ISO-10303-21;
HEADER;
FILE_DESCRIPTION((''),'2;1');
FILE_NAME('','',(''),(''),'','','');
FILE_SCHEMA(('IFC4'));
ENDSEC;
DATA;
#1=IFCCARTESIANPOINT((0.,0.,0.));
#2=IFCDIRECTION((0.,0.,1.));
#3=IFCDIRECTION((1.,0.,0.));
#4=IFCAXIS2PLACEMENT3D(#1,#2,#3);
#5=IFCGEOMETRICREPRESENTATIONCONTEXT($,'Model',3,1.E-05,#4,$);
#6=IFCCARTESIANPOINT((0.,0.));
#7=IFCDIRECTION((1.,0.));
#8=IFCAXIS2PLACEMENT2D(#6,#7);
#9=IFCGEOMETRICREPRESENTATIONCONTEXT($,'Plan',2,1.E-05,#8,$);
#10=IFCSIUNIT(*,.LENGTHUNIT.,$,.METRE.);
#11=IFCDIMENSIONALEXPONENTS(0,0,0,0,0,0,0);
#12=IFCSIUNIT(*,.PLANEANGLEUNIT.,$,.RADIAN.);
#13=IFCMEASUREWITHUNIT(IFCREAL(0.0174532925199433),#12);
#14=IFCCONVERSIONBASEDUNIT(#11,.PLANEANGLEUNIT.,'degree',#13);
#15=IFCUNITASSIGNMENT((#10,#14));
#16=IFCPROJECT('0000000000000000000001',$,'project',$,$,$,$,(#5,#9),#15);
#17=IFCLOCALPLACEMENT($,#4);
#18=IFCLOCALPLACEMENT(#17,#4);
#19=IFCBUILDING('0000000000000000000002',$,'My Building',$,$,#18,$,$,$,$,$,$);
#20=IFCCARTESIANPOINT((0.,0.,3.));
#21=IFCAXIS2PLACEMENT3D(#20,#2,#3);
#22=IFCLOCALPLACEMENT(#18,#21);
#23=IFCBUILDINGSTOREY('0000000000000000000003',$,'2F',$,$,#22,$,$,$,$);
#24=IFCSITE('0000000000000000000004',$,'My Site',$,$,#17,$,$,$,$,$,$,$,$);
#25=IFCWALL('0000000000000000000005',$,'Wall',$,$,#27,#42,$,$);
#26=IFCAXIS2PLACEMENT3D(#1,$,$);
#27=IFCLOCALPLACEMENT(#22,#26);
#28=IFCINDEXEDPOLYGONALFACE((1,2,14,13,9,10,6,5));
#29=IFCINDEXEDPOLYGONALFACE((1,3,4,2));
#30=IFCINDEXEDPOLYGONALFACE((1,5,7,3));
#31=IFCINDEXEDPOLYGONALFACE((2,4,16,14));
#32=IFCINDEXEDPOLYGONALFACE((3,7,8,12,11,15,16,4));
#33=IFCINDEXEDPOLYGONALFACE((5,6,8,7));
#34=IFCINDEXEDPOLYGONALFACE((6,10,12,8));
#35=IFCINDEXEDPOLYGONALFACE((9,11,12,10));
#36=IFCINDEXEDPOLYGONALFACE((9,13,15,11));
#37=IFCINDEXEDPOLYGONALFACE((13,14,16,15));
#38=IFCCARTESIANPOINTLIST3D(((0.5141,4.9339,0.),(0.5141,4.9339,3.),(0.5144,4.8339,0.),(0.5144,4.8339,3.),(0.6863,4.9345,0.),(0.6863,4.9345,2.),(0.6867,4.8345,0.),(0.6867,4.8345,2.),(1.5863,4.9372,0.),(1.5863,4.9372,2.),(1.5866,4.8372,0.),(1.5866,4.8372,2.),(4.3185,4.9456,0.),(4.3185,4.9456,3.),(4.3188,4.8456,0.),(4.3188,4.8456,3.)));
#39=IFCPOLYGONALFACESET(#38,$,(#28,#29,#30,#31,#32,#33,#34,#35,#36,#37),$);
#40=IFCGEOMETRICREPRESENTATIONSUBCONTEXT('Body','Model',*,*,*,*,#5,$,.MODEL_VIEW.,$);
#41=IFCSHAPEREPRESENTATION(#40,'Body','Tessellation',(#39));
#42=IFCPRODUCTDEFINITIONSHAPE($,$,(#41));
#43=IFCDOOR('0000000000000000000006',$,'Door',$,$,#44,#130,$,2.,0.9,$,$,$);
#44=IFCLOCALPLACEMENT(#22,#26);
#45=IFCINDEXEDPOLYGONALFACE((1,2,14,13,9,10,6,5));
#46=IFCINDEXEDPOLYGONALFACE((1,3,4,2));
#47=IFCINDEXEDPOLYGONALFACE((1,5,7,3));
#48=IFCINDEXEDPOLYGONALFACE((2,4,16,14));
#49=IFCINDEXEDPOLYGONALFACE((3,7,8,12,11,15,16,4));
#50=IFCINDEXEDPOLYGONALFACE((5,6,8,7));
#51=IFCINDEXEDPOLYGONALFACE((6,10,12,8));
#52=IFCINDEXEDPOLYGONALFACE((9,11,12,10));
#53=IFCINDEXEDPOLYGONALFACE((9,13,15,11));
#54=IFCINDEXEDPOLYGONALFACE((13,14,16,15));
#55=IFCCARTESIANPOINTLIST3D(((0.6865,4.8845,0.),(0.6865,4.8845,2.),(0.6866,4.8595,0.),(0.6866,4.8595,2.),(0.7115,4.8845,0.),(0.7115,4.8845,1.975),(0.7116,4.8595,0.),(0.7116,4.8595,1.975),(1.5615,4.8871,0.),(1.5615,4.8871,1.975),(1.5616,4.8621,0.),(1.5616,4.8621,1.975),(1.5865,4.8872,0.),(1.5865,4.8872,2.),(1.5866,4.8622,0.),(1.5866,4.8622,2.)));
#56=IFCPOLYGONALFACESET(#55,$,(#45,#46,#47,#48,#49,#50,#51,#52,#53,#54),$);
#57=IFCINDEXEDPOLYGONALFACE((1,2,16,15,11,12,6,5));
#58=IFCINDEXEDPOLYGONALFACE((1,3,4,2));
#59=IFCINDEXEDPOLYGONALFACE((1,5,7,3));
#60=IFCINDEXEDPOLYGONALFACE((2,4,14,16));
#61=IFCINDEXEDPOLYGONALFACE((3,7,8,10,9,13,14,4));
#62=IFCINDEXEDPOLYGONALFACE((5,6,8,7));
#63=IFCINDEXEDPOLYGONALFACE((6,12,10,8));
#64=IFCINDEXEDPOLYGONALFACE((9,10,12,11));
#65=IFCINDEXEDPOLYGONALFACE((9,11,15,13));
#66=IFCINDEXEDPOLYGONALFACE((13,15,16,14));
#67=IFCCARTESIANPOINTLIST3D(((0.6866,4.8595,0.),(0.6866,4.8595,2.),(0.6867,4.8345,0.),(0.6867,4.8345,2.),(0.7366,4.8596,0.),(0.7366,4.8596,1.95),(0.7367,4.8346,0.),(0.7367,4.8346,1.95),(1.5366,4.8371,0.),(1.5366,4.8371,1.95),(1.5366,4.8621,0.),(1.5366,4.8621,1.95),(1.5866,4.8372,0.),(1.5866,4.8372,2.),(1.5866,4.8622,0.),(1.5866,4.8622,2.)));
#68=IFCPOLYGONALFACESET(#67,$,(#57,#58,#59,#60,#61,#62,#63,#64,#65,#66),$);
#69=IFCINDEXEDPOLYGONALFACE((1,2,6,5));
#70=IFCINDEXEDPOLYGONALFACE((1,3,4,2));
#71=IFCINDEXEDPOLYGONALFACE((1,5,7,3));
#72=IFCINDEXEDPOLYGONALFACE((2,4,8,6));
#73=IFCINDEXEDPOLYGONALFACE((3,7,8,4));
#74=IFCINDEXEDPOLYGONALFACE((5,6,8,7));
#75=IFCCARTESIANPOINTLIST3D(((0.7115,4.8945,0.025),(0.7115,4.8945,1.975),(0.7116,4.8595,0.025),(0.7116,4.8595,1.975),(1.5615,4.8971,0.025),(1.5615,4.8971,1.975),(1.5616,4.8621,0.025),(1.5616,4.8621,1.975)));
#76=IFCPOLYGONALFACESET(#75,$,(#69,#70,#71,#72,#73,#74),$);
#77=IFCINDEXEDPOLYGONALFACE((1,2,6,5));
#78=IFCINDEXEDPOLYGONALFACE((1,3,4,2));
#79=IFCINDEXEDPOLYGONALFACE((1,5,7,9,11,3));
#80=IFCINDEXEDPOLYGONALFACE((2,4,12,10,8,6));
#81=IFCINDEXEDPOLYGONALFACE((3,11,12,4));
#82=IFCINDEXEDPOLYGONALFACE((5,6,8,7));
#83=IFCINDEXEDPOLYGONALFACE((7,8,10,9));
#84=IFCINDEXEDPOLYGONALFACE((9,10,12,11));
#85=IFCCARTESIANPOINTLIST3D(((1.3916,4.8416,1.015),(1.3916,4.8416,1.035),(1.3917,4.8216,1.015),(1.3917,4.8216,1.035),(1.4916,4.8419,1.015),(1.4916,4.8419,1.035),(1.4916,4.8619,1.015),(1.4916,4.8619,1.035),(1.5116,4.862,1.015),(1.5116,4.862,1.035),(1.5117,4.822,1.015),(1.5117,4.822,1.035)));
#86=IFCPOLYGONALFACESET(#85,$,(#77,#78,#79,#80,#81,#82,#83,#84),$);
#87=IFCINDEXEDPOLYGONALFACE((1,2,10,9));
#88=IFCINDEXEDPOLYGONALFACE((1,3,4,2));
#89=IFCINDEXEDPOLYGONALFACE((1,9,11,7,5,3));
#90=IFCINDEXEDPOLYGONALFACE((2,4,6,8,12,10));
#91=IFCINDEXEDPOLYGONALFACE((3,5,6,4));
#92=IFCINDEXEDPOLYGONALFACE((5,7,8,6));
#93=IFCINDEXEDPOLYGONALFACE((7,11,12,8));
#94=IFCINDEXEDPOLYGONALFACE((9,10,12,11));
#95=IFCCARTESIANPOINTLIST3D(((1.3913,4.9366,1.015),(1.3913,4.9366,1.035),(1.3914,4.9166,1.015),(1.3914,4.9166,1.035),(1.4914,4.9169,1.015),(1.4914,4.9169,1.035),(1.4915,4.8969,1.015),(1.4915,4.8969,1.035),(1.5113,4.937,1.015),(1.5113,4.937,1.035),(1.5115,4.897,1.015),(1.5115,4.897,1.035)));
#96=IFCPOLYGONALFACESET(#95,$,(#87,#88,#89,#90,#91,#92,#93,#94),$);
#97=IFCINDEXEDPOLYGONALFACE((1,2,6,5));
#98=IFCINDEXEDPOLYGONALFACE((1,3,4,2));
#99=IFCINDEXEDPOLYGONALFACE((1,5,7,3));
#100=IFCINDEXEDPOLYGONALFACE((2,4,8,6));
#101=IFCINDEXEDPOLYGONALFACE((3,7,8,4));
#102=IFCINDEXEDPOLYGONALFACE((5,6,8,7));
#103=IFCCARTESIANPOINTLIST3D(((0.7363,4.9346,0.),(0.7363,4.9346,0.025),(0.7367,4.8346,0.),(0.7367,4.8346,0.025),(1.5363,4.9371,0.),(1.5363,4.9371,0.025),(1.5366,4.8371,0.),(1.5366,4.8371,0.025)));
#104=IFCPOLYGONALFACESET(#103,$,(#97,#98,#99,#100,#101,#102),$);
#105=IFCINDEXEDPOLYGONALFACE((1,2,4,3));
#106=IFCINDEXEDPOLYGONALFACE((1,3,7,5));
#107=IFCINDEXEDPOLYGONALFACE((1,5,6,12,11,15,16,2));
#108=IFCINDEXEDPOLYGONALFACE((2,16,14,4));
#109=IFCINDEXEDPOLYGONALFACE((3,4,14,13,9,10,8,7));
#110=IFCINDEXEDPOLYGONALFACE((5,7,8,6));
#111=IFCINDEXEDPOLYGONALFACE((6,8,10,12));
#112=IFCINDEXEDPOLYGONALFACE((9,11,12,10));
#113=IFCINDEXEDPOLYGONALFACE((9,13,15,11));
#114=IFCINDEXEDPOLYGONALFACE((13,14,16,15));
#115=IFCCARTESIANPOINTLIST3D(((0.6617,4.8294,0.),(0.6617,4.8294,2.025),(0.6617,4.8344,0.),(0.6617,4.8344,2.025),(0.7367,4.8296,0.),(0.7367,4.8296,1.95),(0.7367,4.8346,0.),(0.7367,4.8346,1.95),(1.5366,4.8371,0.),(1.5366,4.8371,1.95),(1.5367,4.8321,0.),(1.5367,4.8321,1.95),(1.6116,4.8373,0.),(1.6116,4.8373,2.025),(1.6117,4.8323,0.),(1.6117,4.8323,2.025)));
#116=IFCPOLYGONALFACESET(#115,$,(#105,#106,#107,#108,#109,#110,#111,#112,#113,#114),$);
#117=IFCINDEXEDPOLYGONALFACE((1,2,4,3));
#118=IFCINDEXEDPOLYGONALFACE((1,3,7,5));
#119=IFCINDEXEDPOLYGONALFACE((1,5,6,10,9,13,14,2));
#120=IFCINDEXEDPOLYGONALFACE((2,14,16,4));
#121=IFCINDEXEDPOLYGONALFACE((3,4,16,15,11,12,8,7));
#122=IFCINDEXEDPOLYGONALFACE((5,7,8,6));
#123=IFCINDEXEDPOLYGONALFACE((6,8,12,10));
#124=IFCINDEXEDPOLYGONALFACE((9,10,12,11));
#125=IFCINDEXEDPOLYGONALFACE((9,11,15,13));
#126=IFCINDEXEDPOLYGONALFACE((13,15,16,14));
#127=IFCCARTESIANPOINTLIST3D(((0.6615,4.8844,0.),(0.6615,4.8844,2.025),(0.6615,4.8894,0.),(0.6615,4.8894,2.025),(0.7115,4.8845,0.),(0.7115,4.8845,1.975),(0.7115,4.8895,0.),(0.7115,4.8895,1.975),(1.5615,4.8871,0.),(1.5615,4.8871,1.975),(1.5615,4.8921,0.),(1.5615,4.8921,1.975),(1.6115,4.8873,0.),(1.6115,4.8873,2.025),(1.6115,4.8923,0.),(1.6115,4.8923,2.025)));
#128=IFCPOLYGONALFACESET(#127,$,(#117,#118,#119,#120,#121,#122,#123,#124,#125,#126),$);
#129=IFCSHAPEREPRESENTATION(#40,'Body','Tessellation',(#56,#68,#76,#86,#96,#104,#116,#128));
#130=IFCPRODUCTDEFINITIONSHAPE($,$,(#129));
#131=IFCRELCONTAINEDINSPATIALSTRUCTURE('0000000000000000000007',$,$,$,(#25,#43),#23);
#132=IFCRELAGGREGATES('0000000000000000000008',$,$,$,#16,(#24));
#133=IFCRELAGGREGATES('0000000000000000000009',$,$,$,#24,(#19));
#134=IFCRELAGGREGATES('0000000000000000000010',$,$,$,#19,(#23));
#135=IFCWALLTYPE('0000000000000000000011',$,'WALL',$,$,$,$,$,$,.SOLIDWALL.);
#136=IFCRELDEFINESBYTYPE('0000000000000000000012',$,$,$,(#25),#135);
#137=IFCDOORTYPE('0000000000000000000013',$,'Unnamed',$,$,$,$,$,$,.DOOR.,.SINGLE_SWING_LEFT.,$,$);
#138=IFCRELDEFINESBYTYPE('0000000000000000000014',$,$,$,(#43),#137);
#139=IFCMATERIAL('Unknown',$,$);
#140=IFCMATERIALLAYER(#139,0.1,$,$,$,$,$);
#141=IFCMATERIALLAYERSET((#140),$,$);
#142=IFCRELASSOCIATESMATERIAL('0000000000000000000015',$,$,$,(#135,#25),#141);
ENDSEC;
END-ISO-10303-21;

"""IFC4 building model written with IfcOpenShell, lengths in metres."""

from ifc_helpers import new_model, entity, si_unit, converted_unit, frame, origin_with_axes, origin_2d_with_axis, place, context, subcontext, project, spatial, line, indexed_curve, outline, extrude, shape, source, transform, mapped, material, layer, layer_set, layer_usage, type_object, type_shapes, element, fill, save


model = new_model("IFC4")

# Units and contexts
model_context = context("Model", 3, precision=1e-05, world=origin_with_axes())
plan_context = context("Plan", 2, precision=1e-05, world=origin_2d_with_axis())
body_context_1 = subcontext(model_context, "Body", "Model", "MODEL_VIEW")
body_context_2 = subcontext(plan_context, "Body", "Plan", "PLAN_VIEW")
ifc_project = project(units=[si_unit("LENGTHUNIT", "METRE"), converted_unit("PLANEANGLEUNIT", "degree", entity("IfcReal", 0.0174532925199433), si_unit("PLANEANGLEUNIT", "RADIAN"), dimensions=[0, 0, 0, 0, 0, 0, 0])], contexts=[model_context, plan_context])

# Site, building, storey
site_placement = place(None, origin_with_axes())
site = spatial("IfcSite", under=ifc_project, at=site_placement, Name="My Site")
building_placement = place(site_placement, origin_with_axes())
building = spatial("IfcBuilding", under=site, at=building_placement, Name="My Building")
storey_placement = place(building_placement, frame((0.0, 0.0, 3.0), z_axis=(0.0, 0.0, 1.0), x_axis=(1.0, 0.0, 0.0)))
storey = spatial("IfcBuildingStorey", under=building, at=storey_placement, Name="2F")

# Shared definitions
ifc_material = material(Name="Unknown")

# Shared definitions
ifc_layer_1 = layer(ifc_material, 0.1)
ifc_layer_set_1 = layer_set([ifc_layer_1])
wall_type = type_object("IfcWallType", Name="WALL", PredefinedType="SOLIDWALL", material=ifc_layer_set_1)

# Shared definitions
shared_shape_1 = source(origin_with_axes(), body_context_1, "Body", "SweptSolid", [
    extrude(outline(indexed_curve([(0.0, 0.0), (0.9, 0.0), (0.9, 2.0), (0.0, 2.0)], segments=[line(1, 2, 3, 4, 1)])), frame((0.0, -0.6, 0.0), z_axis=(0.0, -1.0, 0.0), x_axis=(1.0, 0.0, 0.0)), (0.0, 0.0, -1.0), 1.2),
])
door_type = type_object("IfcDoorType", Name="Unnamed", OperationType="SINGLE_SWING_LEFT", PredefinedType="DOOR")
shared_shape_2 = source(origin_with_axes(), body_context_1, "Body", "SweptSolid", [
    extrude(outline(indexed_curve([(0.0, 0.0), (0.0, 2.0), (0.9, 2.0), (0.9, 0.0), (0.875, 0.0), (0.875, 1.975), (0.025, 1.975), (0.025, 0.0)], segments=[line(1, 2, 3, 4, 5, 6, 7, 8, 1)])), frame((0.0, 0.025, 0.0), z_axis=(0.0, -1.0, 0.0), x_axis=(1.0, 0.0, 0.0)), (0.0, 0.0, -1.0), 0.025),
    extrude(outline(indexed_curve([(0.0, 0.0), (0.0, 2.0), (0.9, 2.0), (0.9, 0.0), (0.85, 0.0), (0.85, 1.95), (0.05, 1.95), (0.05, 0.0)], segments=[line(1, 2, 3, 4, 5, 6, 7, 8, 1)])), frame((0.0, 0.0, 0.0), z_axis=(0.0, -1.0, 0.0), x_axis=(1.0, 0.0, 0.0)), (0.0, 0.0, -1.0), 0.025),
    extrude(outline(indexed_curve([(0.0, 0.0), (0.85, 0.0), (0.85, 0.035), (0.0, 0.035)], segments=[line(1, 2, 3, 4, 1)])), frame((0.025, 0.025, 0.025), z_axis=(0.0, 0.0, 1.0), x_axis=(1.0, 0.0, 0.0)), (0.0, 0.0, 1.0), 1.95),
    extrude(outline(indexed_curve([(0.0, 0.0), (0.0, -0.04), (-0.12, -0.04), (-0.12, -0.02), (-0.02, -0.02), (-0.02, 0.0)], segments=[line(1, 2, 3, 4, 5, 6, 1)])), frame((0.825, 0.025, 1.015), z_axis=(0.0, 0.0, 1.0), x_axis=(1.0, 0.0, 0.0)), (0.0, 0.0, 1.0), 0.02),
    extrude(outline(indexed_curve([(0.0, 0.0), (0.0, 0.04), (-0.12, 0.04), (-0.12, 0.02), (-0.02, 0.02), (-0.02, 0.0)], segments=[line(1, 2, 3, 4, 5, 6, 1)])), frame((0.825, 0.06, 1.015), z_axis=(0.0, 0.0, 1.0), x_axis=(1.0, 0.0, 0.0)), (0.0, 0.0, 1.0), 0.02),
    extrude(outline(indexed_curve([(0.0, 0.0), (0.8, 0.0), (0.8, 0.1), (0.0, 0.1)], segments=[line(1, 2, 3, 4, 1)])), frame((0.05, 0.0, 0.0), z_axis=(0.0, 0.0, 1.0), x_axis=(1.0, 0.0, 0.0)), (0.0, 0.0, 1.0), 0.025),
    extrude(outline(indexed_curve([(0.0, 0.0), (0.0, 2.025), (0.95, 2.025), (0.95, 0.0), (0.875, 0.0), (0.875, 1.95), (0.075, 1.95), (0.075, 0.0)], segments=[line(1, 2, 3, 4, 5, 6, 7, 8, 1)])), frame((-0.025, -0.005, 0.0), z_axis=(0.0, -1.0, 0.0), x_axis=(1.0, 0.0, 0.0)), (0.0, 0.0, -1.0), 0.005),
    extrude(outline(indexed_curve([(0.0, 0.0), (0.0, 2.025), (0.95, 2.025), (0.95, 0.0), (0.9, 0.0), (0.9, 1.975), (0.05, 1.975), (0.05, 0.0)], segments=[line(1, 2, 3, 4, 5, 6, 7, 8, 1)])), frame((-0.025, 0.05, 0.0), z_axis=(0.0, -1.0, 0.0), x_axis=(1.0, 0.0, 0.0)), (0.0, 0.0, -1.0), 0.005),
])
shared_shape_3 = source(origin_with_axes(), body_context_2, "Body", "Curve2D", [
    entity("IfcIndexedPolyCurve", entity("IfcCartesianPointList2D", [[0.0, 0.0], [0.0, 0.05], [0.025, 0.05], [0.025, 0.025], [0.05, 0.025], [0.05, 0.0]]), [entity("IfcLineIndex", [1, 2, 3, 4, 5, 6, 1])]),
    entity("IfcIndexedPolyCurve", entity("IfcCartesianPointList2D", [[0.9, 0.0], [0.9, 0.05], [0.875, 0.05], [0.875, 0.025], [0.85, 0.025], [0.85, 0.0]]), [entity("IfcLineIndex", [1, 2, 3, 4, 5, 6, 1])]),
    entity("IfcTrimmedCurve", entity("IfcEllipse", entity("IfcAxis2Placement2D", entity("IfcCartesianPoint", [0.06, 0.05]), entity("IfcDirection", [1.0, 0.0])), 0.815, 0.85), [entity("IfcCartesianPoint", [0.875, 0.05])], [entity("IfcCartesianPoint", [0.06, 0.9])], True, "CARTESIAN"),
    entity("IfcIndexedPolyCurve", entity("IfcCartesianPointList2D", [[0.025, 0.05], [0.06, 0.05], [0.06, 0.9], [0.025, 0.9]]), [entity("IfcLineIndex", [1, 2, 3, 4, 1])]),
])
type_shapes(door_type, [shared_shape_2, shared_shape_3])

# Wall, opening, door
ifc_layer_usage_1 = layer_usage(ifc_layer_set_1, "AXIS2", "POSITIVE", 0.0)
wall_1_placement = place(storey_placement, frame((0.5144, 4.8339, 0.0), z_axis=(0.0, 0.0, 1.0), x_axis=(0.999995, 0.003068, 0.0)))
wall_1 = element("IfcWall", 1, at=wall_1_placement, inside=storey, type_object=wall_type, material=ifc_layer_usage_1, Name="Wall", context=body_context_1, shape_type="SweptSolid", body=[
    extrude(outline(indexed_curve([(0.0, 0.0), (0.0, 0.1), (3.8044, 0.1), (3.8044, 0.0)], segments=[line(1, 2, 3, 4, 1)])), origin_with_axes(), (0.0, 0.0, 1.0), 3.0),
])
opening_1_placement = place(wall_1_placement, frame((0.1723, 0.0, 0.0), z_axis=(0.0, 0.0, 1.0), x_axis=(1.0, 0.0, 0.0)))
opening_1 = element("IfcOpeningElement", 2, at=opening_1_placement, cuts=wall_1, PredefinedType="OPENING", context=body_context_1, shape_type="MappedRepresentation", body=[
    mapped(shared_shape_1, transform((0.0, 0.0, 0.0), x_axis=(1.0, 0.0, 0.0), y_axis=(0.0, 1.0, 0.0), z_axis=(0.0, 0.0, 1.0), scale=1.0)),
])
door_1_placement = place(opening_1_placement, frame((0.0, 0.0, 0.0), z_axis=(0.0, 0.0, 1.0), x_axis=(1.0, 0.0, 0.0)))
door_1 = element("IfcDoor", 3, at=door_1_placement, inside=storey, type_object=door_type, Name="Door", OverallHeight=2.0, OverallWidth=0.9, shapes=[
    shape(body_context_1, "Body", "MappedRepresentation", [mapped(shared_shape_2, transform((0.0, 0.0, 0.0), x_axis=(1.0, 0.0, 0.0), y_axis=(0.0, 1.0, 0.0), z_axis=(0.0, 0.0, 1.0), scale=1.0))]),
    shape(body_context_2, "Body", "MappedRepresentation", [mapped(shared_shape_3, transform((0.0, 0.0, 0.0), x_axis=(1.0, 0.0, 0.0), y_axis=(0.0, 1.0, 0.0), z_axis=(0.0, 0.0, 1.0), scale=1.0))]),
])
fill(opening_1, door_1)

save(model, "model.ifc")
